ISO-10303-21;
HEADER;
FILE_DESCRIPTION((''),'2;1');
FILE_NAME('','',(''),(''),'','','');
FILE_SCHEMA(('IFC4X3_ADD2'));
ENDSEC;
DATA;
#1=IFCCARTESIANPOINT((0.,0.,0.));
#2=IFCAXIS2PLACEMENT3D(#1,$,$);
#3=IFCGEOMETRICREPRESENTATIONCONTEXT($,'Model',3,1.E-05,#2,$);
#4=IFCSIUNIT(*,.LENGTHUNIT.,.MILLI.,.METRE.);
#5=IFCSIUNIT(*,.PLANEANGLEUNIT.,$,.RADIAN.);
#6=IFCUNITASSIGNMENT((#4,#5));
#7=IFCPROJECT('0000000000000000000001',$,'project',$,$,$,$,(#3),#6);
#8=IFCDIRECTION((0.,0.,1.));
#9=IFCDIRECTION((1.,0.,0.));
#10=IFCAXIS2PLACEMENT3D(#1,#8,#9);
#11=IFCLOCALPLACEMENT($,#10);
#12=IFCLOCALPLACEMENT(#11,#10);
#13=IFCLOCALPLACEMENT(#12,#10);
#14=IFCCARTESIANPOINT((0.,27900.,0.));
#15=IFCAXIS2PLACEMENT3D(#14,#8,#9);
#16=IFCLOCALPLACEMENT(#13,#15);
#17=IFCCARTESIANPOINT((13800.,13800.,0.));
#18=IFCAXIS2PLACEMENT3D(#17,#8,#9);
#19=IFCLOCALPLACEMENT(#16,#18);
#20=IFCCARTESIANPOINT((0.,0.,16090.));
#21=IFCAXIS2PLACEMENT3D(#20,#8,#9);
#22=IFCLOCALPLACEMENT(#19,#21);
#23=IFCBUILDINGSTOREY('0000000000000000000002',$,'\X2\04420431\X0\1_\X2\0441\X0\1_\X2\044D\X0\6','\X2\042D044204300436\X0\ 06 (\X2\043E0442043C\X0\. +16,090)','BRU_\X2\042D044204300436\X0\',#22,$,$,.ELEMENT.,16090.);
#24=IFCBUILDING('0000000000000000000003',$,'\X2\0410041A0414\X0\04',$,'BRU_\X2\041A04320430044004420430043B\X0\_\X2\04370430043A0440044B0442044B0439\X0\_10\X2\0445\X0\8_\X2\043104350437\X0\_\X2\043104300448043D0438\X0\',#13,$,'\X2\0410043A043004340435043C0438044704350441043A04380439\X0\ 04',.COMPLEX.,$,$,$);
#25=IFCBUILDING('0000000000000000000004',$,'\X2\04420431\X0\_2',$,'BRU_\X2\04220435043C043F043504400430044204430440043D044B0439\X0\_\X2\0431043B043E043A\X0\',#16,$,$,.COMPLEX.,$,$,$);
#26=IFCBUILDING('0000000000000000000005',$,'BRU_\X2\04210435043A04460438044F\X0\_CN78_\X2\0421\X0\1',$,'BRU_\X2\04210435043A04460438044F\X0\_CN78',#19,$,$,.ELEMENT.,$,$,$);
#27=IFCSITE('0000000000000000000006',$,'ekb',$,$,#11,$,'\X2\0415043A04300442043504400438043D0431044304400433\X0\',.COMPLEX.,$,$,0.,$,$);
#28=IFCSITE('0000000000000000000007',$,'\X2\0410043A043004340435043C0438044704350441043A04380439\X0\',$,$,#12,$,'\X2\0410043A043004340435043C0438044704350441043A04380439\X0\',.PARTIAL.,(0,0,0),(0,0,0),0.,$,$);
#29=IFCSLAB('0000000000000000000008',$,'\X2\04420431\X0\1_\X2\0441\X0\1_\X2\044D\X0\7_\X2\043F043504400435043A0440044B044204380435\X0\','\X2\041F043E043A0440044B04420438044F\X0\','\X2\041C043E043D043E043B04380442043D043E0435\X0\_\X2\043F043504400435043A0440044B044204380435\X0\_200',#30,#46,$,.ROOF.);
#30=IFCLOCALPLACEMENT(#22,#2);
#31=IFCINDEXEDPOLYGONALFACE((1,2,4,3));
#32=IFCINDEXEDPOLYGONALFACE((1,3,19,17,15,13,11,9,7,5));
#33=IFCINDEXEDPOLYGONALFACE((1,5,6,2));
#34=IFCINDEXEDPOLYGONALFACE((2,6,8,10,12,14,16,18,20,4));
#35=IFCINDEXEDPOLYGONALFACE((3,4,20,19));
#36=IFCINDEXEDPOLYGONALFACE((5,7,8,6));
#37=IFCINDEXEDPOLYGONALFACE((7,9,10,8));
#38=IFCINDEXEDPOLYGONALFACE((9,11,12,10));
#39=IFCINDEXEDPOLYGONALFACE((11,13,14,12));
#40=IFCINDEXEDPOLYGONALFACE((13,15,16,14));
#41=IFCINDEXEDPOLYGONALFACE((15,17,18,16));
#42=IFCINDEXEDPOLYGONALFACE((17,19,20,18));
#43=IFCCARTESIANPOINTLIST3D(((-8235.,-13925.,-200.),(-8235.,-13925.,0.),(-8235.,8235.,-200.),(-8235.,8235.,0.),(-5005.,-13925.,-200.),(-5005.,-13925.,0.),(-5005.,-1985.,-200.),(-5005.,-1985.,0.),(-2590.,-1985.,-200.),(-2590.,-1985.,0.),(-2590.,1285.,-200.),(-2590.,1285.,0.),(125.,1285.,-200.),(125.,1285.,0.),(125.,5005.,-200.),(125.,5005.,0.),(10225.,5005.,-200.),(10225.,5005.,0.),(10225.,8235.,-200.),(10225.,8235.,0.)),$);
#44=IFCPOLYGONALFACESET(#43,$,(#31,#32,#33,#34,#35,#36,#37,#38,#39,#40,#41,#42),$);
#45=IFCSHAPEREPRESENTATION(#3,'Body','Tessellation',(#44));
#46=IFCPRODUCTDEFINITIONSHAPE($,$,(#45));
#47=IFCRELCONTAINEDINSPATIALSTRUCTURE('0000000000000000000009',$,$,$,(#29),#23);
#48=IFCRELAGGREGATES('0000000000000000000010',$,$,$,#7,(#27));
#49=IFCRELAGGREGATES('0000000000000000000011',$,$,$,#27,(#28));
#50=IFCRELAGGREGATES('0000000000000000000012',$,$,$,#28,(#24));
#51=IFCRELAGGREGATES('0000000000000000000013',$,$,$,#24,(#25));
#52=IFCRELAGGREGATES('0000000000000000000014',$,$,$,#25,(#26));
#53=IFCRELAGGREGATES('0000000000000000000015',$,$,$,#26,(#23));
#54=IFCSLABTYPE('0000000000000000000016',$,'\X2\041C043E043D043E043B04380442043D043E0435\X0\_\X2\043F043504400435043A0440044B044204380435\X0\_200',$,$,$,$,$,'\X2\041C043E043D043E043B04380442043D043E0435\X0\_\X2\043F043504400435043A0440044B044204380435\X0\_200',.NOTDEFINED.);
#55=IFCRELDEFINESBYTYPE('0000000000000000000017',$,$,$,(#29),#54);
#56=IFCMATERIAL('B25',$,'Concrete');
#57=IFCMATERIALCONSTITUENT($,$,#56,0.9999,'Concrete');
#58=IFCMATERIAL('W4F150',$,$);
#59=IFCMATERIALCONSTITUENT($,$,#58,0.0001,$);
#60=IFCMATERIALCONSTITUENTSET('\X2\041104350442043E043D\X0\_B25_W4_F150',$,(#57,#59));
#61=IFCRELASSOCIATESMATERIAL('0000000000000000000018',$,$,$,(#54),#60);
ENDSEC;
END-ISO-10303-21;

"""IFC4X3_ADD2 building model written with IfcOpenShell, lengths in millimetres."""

from ifc_helpers import new_model, si_unit, frame, origin, origin_with_axes, place, context, project, spatial, polyline, outline, extrude, material, constituent, constituent_set, type_object, element, save


model = new_model("IFC4X3_ADD2")

# Units and contexts
model_context = context("Model", 3, precision=1e-05, world=origin())
ifc_project = project(units=[si_unit("LENGTHUNIT", "METRE", prefix="MILLI"), si_unit("PLANEANGLEUNIT", "RADIAN")], contexts=[model_context])

# Sites, buildings, storey
site_1_placement = place(None, origin_with_axes())
site_1 = spatial("IfcSite", under=ifc_project, at=site_1_placement, Name="ekb", LongName="Екатеринбург", CompositionType="COMPLEX", RefElevation=0.0)
site_2_placement = place(site_1_placement, origin_with_axes())
site_2 = spatial("IfcSite", under=site_1, at=site_2_placement, Name="Академический", LongName="Академический", CompositionType="PARTIAL", RefLatitude=(0, 0, 0), RefLongitude=(0, 0, 0), RefElevation=0.0)
building_1_placement = place(site_2_placement, origin_with_axes())
building_1 = spatial("IfcBuilding", under=site_2, at=building_1_placement, Name="АКД04", ObjectType="BRU_Квартал_закрытый_10х8_без_башни", LongName="Академический 04", CompositionType="COMPLEX")
building_2_placement = place(building_1_placement, frame((0.0, 27900.0, 0.0), z_axis=(0.0, 0.0, 1.0), x_axis=(1.0, 0.0, 0.0)))
building_2 = spatial("IfcBuilding", under=building_1, at=building_2_placement, Name="тб_2", ObjectType="BRU_Температурный_блок", CompositionType="COMPLEX")
building_3_placement = place(building_2_placement, frame((13800.0, 13800.0, 0.0), z_axis=(0.0, 0.0, 1.0), x_axis=(1.0, 0.0, 0.0)))
building_3 = spatial("IfcBuilding", under=building_2, at=building_3_placement, Name="BRU_Секция_CN78_С1", ObjectType="BRU_Секция_CN78", CompositionType="ELEMENT")
storey_placement = place(building_3_placement, frame((0.0, 0.0, 16090.0), z_axis=(0.0, 0.0, 1.0), x_axis=(1.0, 0.0, 0.0)))
storey = spatial("IfcBuildingStorey", under=building_3, at=storey_placement, Name="тб1_с1_э6", Description="Этаж 06 (отм. +16,090)", ObjectType="BRU_Этаж", CompositionType="ELEMENT", Elevation=16090.0)

# Slab
ifc_material_1 = material(Name="B25", Category="Concrete")
ifc_constituent_1 = constituent(ifc_material_1, Category="Concrete", fraction=0.9999)
ifc_material_2 = material(Name="W4F150")
ifc_constituent_2 = constituent(ifc_material_2, fraction=0.0001)
ifc_constituent_set = constituent_set(constituents=[ifc_constituent_1, ifc_constituent_2], Name="Бетон_B25_W4_F150")
slab_type = type_object("IfcSlabType", Name="Монолитное_перекрытие_200", ElementType="Монолитное_перекрытие_200", PredefinedType="NOTDEFINED", material=ifc_constituent_set)
slab_placement = place(storey_placement, frame((0.0, 0.0, -200.0), z_axis=(0.0, 0.0, 1.0), x_axis=(1.0, 0.0, 0.0)))
element("IfcSlab", 1, at=slab_placement, inside=storey, type_object=slab_type, Name="тб1_с1_э7_перекрытие", Description="Покрытия", ObjectType="Монолитное_перекрытие_200", PredefinedType="ROOF", context=model_context, shape_type="SweptSolid", body=[
    extrude(outline(polyline([(-8235.0, 8235.0), (-8235.0, -13925.0), (-5005.0, -13925.0), (-5005.0, -1985.0), (-2590.0, -1985.0), (-2590.0, 1285.0), (125.0, 1285.0), (125.0, 5005.0), (10225.0, 5005.0), (10225.0, 8235.0), (-8235.0, 8235.0)])), origin_with_axes(), (0.0, 0.0, 1.0), 200.0),
])

save(model, "model.ifc")
